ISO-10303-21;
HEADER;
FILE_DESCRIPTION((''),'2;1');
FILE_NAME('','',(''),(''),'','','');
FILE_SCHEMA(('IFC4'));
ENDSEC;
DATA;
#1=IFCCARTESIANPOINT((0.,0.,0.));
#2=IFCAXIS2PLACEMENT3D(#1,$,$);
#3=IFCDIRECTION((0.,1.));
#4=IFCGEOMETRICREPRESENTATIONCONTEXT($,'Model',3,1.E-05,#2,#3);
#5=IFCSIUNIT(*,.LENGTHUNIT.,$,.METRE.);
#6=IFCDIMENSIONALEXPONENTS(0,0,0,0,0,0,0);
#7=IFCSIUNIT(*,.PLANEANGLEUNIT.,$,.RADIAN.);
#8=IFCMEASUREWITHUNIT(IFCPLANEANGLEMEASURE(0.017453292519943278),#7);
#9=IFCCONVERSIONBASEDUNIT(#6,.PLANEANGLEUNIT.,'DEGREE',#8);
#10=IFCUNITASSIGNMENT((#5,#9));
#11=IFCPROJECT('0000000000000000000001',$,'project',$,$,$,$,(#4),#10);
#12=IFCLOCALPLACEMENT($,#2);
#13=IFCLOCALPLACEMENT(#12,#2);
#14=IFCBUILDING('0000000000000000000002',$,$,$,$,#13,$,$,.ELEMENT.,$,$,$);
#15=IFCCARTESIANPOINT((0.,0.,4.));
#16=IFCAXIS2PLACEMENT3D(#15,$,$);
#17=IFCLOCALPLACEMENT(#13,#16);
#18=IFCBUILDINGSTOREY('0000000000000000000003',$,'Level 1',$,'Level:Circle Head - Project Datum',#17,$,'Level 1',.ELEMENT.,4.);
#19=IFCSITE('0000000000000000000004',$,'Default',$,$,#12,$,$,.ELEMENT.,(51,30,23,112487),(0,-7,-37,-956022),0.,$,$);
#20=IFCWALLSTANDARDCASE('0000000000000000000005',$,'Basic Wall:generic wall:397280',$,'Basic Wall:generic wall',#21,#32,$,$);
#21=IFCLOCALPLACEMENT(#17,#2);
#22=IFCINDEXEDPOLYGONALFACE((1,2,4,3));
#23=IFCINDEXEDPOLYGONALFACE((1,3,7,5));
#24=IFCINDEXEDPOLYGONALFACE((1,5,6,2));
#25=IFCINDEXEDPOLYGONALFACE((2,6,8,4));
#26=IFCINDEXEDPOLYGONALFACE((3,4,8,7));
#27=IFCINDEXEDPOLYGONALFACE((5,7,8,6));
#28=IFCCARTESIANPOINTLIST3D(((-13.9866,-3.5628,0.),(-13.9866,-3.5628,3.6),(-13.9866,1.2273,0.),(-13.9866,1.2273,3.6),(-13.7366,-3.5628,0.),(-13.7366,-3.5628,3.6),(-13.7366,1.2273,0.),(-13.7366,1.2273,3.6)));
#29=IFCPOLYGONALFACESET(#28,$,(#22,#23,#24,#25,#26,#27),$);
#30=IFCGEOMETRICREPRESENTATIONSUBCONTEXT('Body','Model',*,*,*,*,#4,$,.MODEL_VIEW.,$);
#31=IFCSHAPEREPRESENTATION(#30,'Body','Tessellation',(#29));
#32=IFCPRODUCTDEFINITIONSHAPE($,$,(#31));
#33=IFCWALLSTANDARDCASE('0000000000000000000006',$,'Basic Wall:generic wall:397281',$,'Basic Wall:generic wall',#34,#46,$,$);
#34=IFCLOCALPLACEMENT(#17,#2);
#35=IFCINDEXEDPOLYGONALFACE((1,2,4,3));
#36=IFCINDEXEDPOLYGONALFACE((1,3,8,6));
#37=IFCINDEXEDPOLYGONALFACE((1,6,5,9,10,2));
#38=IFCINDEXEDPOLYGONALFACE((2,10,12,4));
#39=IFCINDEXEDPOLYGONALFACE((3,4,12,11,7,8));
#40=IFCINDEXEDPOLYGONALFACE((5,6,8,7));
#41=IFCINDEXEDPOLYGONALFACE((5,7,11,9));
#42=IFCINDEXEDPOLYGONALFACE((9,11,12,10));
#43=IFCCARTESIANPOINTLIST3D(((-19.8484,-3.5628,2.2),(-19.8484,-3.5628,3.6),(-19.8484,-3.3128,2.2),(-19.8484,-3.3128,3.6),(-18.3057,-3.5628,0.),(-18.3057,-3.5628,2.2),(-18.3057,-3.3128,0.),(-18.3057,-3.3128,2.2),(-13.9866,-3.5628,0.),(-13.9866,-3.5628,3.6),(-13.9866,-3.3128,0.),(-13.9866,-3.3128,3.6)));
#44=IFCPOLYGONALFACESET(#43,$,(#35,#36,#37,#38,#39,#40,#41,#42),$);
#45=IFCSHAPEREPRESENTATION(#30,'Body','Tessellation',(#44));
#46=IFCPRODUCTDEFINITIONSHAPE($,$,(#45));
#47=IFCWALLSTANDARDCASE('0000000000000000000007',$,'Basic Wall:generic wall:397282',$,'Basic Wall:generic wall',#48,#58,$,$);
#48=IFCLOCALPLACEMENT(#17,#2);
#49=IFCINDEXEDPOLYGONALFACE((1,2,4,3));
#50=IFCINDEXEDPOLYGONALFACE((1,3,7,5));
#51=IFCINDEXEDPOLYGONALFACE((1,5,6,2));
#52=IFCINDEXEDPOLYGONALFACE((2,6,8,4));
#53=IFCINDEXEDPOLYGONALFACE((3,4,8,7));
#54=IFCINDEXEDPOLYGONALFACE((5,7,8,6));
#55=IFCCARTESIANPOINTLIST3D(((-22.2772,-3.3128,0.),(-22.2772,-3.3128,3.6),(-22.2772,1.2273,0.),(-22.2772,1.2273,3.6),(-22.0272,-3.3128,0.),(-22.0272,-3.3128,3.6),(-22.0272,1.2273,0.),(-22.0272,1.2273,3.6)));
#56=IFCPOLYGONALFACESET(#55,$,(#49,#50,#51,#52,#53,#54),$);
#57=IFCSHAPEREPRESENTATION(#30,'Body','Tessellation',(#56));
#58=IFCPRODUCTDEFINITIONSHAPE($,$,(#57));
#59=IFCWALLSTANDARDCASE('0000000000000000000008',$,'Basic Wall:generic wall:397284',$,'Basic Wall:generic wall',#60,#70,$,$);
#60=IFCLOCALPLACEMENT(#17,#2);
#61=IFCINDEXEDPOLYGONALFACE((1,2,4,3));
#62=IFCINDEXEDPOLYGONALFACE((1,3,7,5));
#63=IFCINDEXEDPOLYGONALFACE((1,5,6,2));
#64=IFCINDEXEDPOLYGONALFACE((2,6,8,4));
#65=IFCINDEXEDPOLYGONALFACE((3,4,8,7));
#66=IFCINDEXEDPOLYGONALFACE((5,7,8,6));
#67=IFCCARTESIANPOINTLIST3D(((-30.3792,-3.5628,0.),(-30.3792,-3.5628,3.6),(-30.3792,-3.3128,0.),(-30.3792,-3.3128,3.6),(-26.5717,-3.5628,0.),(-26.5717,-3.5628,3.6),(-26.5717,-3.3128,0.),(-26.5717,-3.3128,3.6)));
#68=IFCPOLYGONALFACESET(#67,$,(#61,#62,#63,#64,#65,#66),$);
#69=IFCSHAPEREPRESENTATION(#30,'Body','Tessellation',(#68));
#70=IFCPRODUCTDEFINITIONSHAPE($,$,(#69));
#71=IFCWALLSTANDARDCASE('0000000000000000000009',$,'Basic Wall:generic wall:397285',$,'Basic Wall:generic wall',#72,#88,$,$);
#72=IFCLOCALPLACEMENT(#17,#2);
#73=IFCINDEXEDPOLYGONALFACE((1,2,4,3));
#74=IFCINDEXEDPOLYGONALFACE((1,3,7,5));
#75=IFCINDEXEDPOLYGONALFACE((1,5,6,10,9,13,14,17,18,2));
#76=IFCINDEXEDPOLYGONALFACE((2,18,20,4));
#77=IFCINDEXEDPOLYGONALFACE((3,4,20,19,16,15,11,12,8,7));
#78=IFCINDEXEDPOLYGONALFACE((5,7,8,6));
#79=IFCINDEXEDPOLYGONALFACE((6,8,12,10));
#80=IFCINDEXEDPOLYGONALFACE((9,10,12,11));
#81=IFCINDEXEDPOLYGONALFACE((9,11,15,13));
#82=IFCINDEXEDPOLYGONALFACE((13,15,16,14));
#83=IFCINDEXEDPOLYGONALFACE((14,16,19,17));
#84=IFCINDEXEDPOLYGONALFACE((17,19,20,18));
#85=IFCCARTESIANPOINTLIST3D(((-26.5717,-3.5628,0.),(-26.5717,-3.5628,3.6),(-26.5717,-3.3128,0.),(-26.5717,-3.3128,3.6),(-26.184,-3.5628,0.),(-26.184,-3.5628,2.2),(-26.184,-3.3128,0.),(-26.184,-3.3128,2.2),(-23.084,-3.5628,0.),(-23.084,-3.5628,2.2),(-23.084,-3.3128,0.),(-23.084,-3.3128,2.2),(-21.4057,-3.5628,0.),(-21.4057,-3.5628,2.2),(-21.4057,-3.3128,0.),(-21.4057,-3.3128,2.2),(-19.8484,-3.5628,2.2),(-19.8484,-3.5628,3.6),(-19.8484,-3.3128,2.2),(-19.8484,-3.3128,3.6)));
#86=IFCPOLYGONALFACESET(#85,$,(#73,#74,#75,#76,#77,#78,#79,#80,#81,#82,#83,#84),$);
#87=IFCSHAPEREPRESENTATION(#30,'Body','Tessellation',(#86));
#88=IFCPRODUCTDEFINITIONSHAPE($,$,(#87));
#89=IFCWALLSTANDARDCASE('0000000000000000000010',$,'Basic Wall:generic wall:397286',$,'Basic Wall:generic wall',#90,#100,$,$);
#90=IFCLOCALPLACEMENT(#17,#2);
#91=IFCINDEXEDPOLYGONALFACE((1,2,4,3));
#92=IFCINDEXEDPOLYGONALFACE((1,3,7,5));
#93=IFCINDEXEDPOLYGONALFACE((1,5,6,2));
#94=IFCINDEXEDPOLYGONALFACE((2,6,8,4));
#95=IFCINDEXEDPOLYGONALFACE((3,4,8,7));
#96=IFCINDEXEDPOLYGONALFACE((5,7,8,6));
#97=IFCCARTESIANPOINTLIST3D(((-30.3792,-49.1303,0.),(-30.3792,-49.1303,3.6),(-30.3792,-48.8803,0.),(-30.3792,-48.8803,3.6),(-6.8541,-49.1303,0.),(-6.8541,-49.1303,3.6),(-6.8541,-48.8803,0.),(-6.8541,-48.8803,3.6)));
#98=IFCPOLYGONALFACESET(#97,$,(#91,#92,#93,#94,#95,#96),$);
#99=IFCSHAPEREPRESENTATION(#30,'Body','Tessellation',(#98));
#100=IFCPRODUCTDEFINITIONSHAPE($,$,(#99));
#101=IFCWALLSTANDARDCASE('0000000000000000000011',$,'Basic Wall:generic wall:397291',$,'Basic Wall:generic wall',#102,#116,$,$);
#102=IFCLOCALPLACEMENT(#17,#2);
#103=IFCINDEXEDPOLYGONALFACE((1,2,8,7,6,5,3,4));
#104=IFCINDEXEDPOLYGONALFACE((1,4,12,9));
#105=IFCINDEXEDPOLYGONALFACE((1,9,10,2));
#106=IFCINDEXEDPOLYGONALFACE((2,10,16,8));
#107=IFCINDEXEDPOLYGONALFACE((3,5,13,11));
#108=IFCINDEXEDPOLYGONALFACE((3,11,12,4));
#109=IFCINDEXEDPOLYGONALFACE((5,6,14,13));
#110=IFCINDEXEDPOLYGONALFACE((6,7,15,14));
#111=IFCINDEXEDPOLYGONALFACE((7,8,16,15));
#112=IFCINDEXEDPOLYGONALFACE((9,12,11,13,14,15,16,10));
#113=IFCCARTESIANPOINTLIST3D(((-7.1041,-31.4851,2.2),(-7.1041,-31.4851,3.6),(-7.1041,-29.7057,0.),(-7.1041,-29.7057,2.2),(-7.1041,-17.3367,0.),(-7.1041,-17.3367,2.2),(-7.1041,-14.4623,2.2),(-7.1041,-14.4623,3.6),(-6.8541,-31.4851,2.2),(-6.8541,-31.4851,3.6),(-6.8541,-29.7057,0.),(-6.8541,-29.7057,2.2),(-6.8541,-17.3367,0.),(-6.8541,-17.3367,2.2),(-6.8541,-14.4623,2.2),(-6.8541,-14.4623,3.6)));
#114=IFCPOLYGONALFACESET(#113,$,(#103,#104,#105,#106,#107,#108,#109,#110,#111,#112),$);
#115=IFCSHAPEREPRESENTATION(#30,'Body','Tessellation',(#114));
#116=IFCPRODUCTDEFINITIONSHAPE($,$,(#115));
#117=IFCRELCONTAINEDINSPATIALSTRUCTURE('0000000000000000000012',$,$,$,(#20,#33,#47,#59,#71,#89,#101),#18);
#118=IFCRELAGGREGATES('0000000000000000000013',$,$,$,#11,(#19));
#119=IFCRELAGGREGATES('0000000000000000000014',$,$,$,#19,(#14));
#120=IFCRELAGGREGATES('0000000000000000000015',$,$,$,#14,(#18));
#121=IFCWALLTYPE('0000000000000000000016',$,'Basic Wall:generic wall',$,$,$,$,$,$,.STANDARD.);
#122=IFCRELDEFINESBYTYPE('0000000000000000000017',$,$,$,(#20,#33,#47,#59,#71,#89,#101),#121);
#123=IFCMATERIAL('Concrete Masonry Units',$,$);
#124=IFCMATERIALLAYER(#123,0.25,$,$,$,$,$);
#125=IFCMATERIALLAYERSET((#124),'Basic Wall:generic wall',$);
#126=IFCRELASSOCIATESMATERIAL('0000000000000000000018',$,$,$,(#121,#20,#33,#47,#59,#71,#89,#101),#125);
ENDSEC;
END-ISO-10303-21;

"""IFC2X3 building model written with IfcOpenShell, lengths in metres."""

from ifc_helpers import new_model, entity, si_unit, converted_unit, direction, frame, frame_2d, origin, place, context, subcontext, project, spatial, rectangle, extrude, material, layer, layer_set, layer_usage, type_object, element, save


model = new_model("IFC2X3")

# Units and contexts
model_context = context("Model", 3, precision=1e-05, world=origin(), true_north=direction((0.0, 1.0)))
body_context = subcontext(model_context, "Body", "Model", "MODEL_VIEW")
ifc_project = project(units=[si_unit("LENGTHUNIT", "METRE"), converted_unit("PLANEANGLEUNIT", "DEGREE", entity("IfcPlaneAngleMeasure", 0.017453292519943278), si_unit("PLANEANGLEUNIT", "RADIAN"), dimensions=[0, 0, 0, 0, 0, 0, 0])], contexts=[model_context])

# Site, building, storey
site_placement = place(None, origin())
site = spatial("IfcSite", under=ifc_project, at=site_placement, Name="Default", CompositionType="ELEMENT", RefLatitude=(51, 30, 23, 112487), RefLongitude=(0, -7, -37, -956022), RefElevation=0.0)
building_placement = place(site_placement, origin())
building = spatial("IfcBuilding", under=site, at=building_placement, CompositionType="ELEMENT")
storey_placement = place(building_placement, frame((0.0, 0.0, 4.0)))
storey = spatial("IfcBuildingStorey", under=building, at=storey_placement, Name="Level 1", ObjectType="Level:Circle Head - Project Datum", LongName="Level 1", CompositionType="ELEMENT", Elevation=4.0)

# Wall
ifc_material_1 = material(Name="Concrete Masonry Units")
ifc_layer_1 = layer(ifc_material_1, 0.25)
ifc_layer_set_1 = layer_set([ifc_layer_1], Name="Basic Wall:generic wall")
ifc_layer_usage_1 = layer_usage(ifc_layer_set_1, "AXIS2", "NEGATIVE", 0.125)
wall_type = type_object("IfcWallType", Name="Basic Wall:generic wall", PredefinedType="STANDARD", material=ifc_layer_set_1)
wall_1_placement = place(storey_placement, frame((-13.8616, 1.2273, 0.0), z_axis=(0.0, 0.0, 1.0), x_axis=(0.0, -1.0, 0.0)))
element("IfcWallStandardCase", 1, at=wall_1_placement, inside=storey, type_object=wall_type, material=ifc_layer_usage_1, Name="Basic Wall:generic wall:397280", ObjectType="Basic Wall:generic wall", context=body_context, shape_type="SweptSolid", body=[
    extrude(rectangle(XDim=4.7901, YDim=0.25, at=frame_2d((2.3951, 0.0), x_axis=(-1.0, 0.0))), origin(), (0.0, 0.0, 1.0), 3.6),
])

# Wall, opening
ifc_layer_usage_2 = layer_usage(ifc_layer_set_1, "AXIS2", "NEGATIVE", 0.125)
wall_2_placement = place(storey_placement, frame((-13.9866, -3.4378, 0.0), z_axis=(0.0, 0.0, 1.0), x_axis=(-1.0, 0.0, 0.0)))
wall_2 = element("IfcWallStandardCase", 2, at=wall_2_placement, inside=storey, type_object=wall_type, material=ifc_layer_usage_2, Name="Basic Wall:generic wall:397281", ObjectType="Basic Wall:generic wall", context=body_context, shape_type="SweptSolid", body=[
    extrude(rectangle(XDim=5.8618, YDim=0.25, at=frame_2d((2.9309, 0.0), x_axis=(-1.0, 0.0))), origin(), (0.0, 0.0, 1.0), 3.6),
])
opening_1_placement = place(wall_2_placement, frame((7.4191, 0.125, 0.0)))
element("IfcOpeningElement", 3, at=opening_1_placement, cuts=wall_2, ObjectType="Opening", context=body_context, shape_type="SweptSolid", body=[
    extrude(rectangle(XDim=2.2, YDim=3.1, at=frame_2d((1.1, 1.55), x_axis=(1.0, 0.0))), frame((0.0, 0.0, 0.0), z_axis=(0.0, -1.0, 0.0), x_axis=(0.0, 0.0, 1.0)), (0.0, 0.0, 1.0), 0.25),
])

# Walls
ifc_layer_usage_3 = layer_usage(ifc_layer_set_1, "AXIS2", "NEGATIVE", 0.125)
wall_3_placement = place(storey_placement, frame((-22.1522, 1.2273, 0.0), z_axis=(0.0, 0.0, 1.0), x_axis=(0.0, -1.0, 0.0)))
element("IfcWallStandardCase", 4, at=wall_3_placement, inside=storey, type_object=wall_type, material=ifc_layer_usage_3, Name="Basic Wall:generic wall:397282", ObjectType="Basic Wall:generic wall", context=body_context, shape_type="SweptSolid", body=[
    extrude(rectangle(XDim=4.5401, YDim=0.25, at=frame_2d((2.2701, 0.0), x_axis=(-1.0, 0.0))), origin(), (0.0, 0.0, 1.0), 3.6),
])
ifc_layer_usage_4 = layer_usage(ifc_layer_set_1, "AXIS2", "NEGATIVE", 0.125)
wall_4_placement = place(storey_placement, frame((-30.3792, -3.4378, 0.0)))
element("IfcWallStandardCase", 5, at=wall_4_placement, inside=storey, type_object=wall_type, material=ifc_layer_usage_4, Name="Basic Wall:generic wall:397284", ObjectType="Basic Wall:generic wall", context=body_context, shape_type="SweptSolid", body=[
    extrude(rectangle(XDim=3.8075, YDim=0.25, at=frame_2d((1.9038, 0.0), x_axis=(-1.0, 0.0))), origin(), (0.0, 0.0, 1.0), 3.6),
])

# Wall, openings
ifc_layer_usage_5 = layer_usage(ifc_layer_set_1, "AXIS2", "NEGATIVE", 0.125)
wall_5_placement = place(storey_placement, frame((-19.8484, -3.4378, 0.0), z_axis=(0.0, 0.0, 1.0), x_axis=(-1.0, 0.0, 0.0)))
wall_5 = element("IfcWallStandardCase", 6, at=wall_5_placement, inside=storey, type_object=wall_type, material=ifc_layer_usage_5, Name="Basic Wall:generic wall:397285", ObjectType="Basic Wall:generic wall", context=body_context, shape_type="SweptSolid", body=[
    extrude(rectangle(XDim=6.7233, YDim=0.25, at=frame_2d((3.3616, 0.0), x_axis=(1.0, 0.0))), origin(), (0.0, 0.0, 1.0), 3.6),
])
opening_2_placement = place(wall_5_placement, origin())
element("IfcOpeningElement", 7, at=opening_2_placement, cuts=wall_5, ObjectType="Opening", context=body_context, shape_type="SweptSolid", body=[
    extrude(rectangle(XDim=2.2, YDim=3.1, at=frame_2d((0.0, 0.0), x_axis=(1.0, 0.0))), frame((0.0073, -1.399, 1.1), z_axis=(0.0, 1.0, 0.0), x_axis=(0.0, 0.0, 1.0)), (0.0, 0.0, 1.0), 3.048),
])
opening_3_placement = place(wall_5_placement, frame((6.3356, 0.125, 0.0)))
element("IfcOpeningElement", 8, at=opening_3_placement, cuts=wall_5, ObjectType="Opening", context=body_context, shape_type="SweptSolid", body=[
    extrude(rectangle(XDim=2.2, YDim=3.1, at=frame_2d((1.1, 1.55), x_axis=(1.0, 0.0))), frame((0.0, 0.0, 0.0), z_axis=(0.0, -1.0, 0.0), x_axis=(0.0, 0.0, 1.0)), (0.0, 0.0, 1.0), 0.25),
])

# Wall
ifc_layer_usage_6 = layer_usage(ifc_layer_set_1, "AXIS2", "NEGATIVE", 0.125)
wall_6_placement = place(storey_placement, frame((-30.3792, -49.0053, 0.0)))
element("IfcWallStandardCase", 9, at=wall_6_placement, inside=storey, type_object=wall_type, material=ifc_layer_usage_6, Name="Basic Wall:generic wall:397286", ObjectType="Basic Wall:generic wall", context=body_context, shape_type="SweptSolid", body=[
    extrude(rectangle(XDim=23.5251, YDim=0.25, at=frame_2d((11.7625, 0.0), x_axis=(-1.0, 0.0))), origin(), (0.0, 0.0, 1.0), 3.6),
])

# Wall, openings
ifc_layer_usage_7 = layer_usage(ifc_layer_set_1, "AXIS2", "NEGATIVE", 0.125)
wall_7_placement = place(storey_placement, frame((-6.9791, -31.4851, 0.0), z_axis=(0.0, 0.0, 1.0), x_axis=(0.0, 1.0, 0.0)))
wall_7 = element("IfcWallStandardCase", 10, at=wall_7_placement, inside=storey, type_object=wall_type, material=ifc_layer_usage_7, Name="Basic Wall:generic wall:397291", ObjectType="Basic Wall:generic wall", context=body_context, shape_type="SweptSolid", body=[
    extrude(rectangle(XDim=17.0228, YDim=0.25, at=frame_2d((8.5114, 0.0), x_axis=(-1.0, 0.0))), origin(), (0.0, 0.0, 1.0), 3.6),
])
opening_4_placement = place(wall_7_placement, frame((17.2484, 0.125, 0.0)))
element("IfcOpeningElement", 11, at=opening_4_placement, cuts=wall_7, ObjectType="Opening", context=body_context, shape_type="SweptSolid", body=[
    extrude(rectangle(XDim=2.2, YDim=3.1, at=frame_2d((1.1, 1.55), x_axis=(1.0, 0.0))), frame((0.0, 0.0, 0.0), z_axis=(0.0, -1.0, 0.0), x_axis=(0.0, 0.0, 1.0)), (0.0, 0.0, 1.0), 0.25),
])
opening_5_placement = place(wall_7_placement, frame((1.7793, 0.125, 0.0)))
element("IfcOpeningElement", 12, at=opening_5_placement, cuts=wall_7, ObjectType="Opening", context=body_context, shape_type="SweptSolid", body=[
    extrude(rectangle(XDim=2.2, YDim=3.1, at=frame_2d((1.1, 1.55), x_axis=(1.0, 0.0))), frame((0.0, 0.0, 0.0), z_axis=(0.0, -1.0, 0.0), x_axis=(0.0, 0.0, 1.0)), (0.0, 0.0, 1.0), 0.25),
])

save(model, "model.ifc")
